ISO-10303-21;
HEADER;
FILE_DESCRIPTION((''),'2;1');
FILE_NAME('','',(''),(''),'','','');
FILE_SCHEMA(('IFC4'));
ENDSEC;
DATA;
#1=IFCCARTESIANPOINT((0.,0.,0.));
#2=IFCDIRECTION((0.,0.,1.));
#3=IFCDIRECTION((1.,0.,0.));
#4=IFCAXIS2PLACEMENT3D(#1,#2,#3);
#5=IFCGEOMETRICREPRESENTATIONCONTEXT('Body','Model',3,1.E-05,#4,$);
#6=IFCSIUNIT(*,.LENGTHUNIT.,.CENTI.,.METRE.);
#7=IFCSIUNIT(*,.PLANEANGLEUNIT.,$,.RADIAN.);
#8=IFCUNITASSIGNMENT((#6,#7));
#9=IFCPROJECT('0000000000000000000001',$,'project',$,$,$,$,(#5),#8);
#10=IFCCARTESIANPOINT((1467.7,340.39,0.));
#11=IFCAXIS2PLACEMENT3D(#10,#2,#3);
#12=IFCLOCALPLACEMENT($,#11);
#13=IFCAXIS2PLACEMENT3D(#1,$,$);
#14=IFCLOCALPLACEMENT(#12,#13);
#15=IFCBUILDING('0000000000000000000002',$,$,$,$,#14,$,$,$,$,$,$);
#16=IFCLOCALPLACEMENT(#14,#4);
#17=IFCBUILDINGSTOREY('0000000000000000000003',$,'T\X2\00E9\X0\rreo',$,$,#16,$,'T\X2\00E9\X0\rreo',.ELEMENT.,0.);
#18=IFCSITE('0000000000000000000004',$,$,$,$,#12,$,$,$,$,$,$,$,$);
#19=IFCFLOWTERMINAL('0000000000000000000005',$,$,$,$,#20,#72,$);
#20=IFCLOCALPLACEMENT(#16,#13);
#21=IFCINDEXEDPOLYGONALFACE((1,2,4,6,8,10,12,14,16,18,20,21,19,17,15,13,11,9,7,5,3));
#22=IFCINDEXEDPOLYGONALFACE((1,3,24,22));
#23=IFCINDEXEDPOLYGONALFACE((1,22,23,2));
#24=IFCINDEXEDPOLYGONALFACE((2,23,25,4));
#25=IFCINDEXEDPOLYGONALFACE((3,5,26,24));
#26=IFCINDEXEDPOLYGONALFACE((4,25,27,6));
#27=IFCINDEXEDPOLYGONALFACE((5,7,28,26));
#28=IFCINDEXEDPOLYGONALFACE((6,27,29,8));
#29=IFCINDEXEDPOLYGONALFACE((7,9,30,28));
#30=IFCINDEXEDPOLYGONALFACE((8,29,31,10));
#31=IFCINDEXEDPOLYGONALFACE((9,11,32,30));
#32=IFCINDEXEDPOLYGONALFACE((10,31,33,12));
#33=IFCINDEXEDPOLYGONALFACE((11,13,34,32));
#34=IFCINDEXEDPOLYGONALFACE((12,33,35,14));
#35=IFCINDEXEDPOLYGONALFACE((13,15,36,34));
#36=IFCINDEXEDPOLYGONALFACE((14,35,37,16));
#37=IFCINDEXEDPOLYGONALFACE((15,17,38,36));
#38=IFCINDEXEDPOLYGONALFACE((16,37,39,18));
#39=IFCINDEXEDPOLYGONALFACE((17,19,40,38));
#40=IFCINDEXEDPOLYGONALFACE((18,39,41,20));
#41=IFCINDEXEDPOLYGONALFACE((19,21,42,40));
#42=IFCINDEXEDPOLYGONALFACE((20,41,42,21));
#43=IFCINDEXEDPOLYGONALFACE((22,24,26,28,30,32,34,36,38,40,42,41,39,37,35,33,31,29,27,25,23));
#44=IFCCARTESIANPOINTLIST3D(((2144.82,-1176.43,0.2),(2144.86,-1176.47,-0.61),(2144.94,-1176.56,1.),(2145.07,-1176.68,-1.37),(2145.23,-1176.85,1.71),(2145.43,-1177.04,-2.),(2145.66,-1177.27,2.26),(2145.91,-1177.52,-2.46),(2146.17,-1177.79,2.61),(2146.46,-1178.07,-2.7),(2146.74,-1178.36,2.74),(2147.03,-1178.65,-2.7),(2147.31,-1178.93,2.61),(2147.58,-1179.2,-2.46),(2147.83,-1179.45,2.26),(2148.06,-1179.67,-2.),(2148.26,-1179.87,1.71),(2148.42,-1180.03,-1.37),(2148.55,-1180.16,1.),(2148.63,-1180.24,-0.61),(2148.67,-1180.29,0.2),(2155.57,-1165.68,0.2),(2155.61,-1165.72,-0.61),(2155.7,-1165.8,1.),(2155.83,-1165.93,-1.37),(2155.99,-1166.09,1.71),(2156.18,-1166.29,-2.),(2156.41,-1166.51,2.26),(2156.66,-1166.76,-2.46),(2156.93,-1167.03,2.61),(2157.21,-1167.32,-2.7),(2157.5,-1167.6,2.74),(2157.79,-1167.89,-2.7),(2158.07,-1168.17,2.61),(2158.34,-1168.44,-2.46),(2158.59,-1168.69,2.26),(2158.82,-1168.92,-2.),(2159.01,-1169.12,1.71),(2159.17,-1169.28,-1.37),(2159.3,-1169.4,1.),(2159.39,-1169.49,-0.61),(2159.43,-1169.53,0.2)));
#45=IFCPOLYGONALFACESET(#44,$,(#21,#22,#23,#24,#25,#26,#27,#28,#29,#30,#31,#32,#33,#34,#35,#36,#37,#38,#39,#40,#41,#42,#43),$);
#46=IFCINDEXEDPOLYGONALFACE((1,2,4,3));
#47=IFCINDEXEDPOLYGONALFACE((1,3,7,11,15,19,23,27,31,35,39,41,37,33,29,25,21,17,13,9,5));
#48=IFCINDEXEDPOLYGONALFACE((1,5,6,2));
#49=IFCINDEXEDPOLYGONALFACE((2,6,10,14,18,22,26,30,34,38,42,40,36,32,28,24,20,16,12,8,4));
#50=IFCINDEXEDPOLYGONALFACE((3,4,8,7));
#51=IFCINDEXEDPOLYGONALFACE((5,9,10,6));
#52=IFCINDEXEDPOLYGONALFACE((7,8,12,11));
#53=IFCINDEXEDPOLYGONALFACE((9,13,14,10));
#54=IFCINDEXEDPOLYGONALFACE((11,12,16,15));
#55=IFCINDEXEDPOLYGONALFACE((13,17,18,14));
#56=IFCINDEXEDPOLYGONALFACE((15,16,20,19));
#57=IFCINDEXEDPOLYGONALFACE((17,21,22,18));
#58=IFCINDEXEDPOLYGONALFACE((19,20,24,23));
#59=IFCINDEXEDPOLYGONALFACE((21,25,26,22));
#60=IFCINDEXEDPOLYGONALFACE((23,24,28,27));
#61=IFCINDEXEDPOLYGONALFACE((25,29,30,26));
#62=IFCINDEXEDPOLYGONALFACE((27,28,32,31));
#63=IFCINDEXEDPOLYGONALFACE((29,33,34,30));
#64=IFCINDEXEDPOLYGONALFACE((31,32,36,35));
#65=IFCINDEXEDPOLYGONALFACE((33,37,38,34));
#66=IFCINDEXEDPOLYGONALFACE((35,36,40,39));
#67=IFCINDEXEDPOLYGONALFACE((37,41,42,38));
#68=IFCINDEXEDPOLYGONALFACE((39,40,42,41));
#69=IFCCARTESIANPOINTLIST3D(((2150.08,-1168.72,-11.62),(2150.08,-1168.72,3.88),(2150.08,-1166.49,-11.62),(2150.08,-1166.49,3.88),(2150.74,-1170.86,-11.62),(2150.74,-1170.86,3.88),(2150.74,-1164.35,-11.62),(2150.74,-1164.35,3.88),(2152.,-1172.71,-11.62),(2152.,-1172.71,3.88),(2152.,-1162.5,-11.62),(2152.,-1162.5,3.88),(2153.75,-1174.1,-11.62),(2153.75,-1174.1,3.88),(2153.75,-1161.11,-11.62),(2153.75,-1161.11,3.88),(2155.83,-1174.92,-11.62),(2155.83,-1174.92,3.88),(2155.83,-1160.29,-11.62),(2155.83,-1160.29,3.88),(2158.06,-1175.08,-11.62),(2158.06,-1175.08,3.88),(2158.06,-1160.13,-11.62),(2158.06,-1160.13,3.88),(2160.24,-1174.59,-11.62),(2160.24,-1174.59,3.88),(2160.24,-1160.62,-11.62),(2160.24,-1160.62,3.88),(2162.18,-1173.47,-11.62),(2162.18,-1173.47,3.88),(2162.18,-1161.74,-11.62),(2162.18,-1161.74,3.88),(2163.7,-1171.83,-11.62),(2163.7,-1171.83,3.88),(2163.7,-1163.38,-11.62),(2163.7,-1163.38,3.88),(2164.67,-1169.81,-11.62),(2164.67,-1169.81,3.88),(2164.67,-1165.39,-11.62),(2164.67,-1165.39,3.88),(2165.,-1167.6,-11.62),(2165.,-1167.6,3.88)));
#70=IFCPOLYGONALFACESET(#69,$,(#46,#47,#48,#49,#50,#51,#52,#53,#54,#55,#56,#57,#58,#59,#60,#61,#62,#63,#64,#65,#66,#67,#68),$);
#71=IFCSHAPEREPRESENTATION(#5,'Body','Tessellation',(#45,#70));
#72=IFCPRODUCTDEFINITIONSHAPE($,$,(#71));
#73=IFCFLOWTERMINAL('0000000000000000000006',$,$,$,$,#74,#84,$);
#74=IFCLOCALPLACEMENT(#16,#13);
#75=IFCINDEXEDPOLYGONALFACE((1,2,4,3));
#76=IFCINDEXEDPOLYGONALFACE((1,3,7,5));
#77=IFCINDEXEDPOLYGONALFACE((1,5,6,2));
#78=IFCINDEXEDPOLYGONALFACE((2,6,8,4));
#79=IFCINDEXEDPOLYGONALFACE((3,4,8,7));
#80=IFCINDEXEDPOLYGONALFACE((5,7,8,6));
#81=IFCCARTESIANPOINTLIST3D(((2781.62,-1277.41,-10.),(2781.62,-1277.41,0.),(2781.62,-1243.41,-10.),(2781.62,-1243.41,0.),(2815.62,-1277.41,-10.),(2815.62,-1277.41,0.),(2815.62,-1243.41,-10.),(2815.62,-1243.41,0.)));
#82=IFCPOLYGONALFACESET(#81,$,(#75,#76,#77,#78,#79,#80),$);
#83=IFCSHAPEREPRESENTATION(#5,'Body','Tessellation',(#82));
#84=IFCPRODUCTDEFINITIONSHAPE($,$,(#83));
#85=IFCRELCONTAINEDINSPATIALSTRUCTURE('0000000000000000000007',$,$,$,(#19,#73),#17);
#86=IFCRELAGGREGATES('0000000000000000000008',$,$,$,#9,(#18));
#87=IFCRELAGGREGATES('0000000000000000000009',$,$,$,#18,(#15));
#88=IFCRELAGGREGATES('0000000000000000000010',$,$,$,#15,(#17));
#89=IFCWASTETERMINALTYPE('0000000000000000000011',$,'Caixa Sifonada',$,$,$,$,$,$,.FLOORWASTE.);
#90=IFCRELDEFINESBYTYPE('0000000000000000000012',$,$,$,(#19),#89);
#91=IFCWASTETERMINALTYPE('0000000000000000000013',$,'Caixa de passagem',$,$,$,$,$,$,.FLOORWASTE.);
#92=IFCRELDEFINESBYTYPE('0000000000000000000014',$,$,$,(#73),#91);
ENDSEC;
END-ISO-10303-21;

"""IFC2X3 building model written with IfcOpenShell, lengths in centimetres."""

from ifc_helpers import new_model, si_unit, frame, origin, origin_with_axes, origin_2d_with_axis, place, context, project, spatial, rectangle, circle, extrude, type_object, element, save


model = new_model("IFC2X3")

# Units and contexts
model_context = context("Model", 3, precision=1e-05, world=origin_with_axes(), identifier="Body")
ifc_project = project(units=[si_unit("LENGTHUNIT", "METRE", prefix="CENTI"), si_unit("PLANEANGLEUNIT", "RADIAN")], contexts=[model_context])

# Site, building, storey
site_placement = place(None, frame((1467.7, 340.39, 0.0), z_axis=(0.0, 0.0, 1.0), x_axis=(1.0, 0.0, 0.0)))
site = spatial("IfcSite", under=ifc_project, at=site_placement)
building_placement = place(site_placement, origin())
building = spatial("IfcBuilding", under=site, at=building_placement)
storey_placement = place(building_placement, origin_with_axes())
storey = spatial("IfcBuildingStorey", under=building, at=storey_placement, Name="Térreo", LongName="Térreo", CompositionType="ELEMENT", Elevation=0.0)

# Flow terminals
waste_terminal_type_1 = type_object("IfcWasteTerminalType", Name="Caixa Sifonada", PredefinedType="FLOORWASTE")
flow_terminal_1_placement = place(storey_placement, frame((2154.91, -1170.2, 3.88), z_axis=(0.0, 0.0, 1.0), x_axis=(1.0, 0.0, 0.0)))
element("IfcFlowTerminal", 1, at=flow_terminal_1_placement, inside=storey, type_object=waste_terminal_type_1, context=model_context, shape_type="SolidModel", body=[
    extrude(circle(Radius=2.73, at=origin_2d_with_axis()), frame((2.59, 2.59, -3.88), z_axis=(-0.707107, -0.707107, 0.0), x_axis=(0.0, 0.0, 1.0)), (0.0, 0.0, 1.0), 15.21),
    extrude(circle(Radius=7.5, at=origin_2d_with_axis()), frame((2.59, 2.59, -15.5), z_axis=(0.0, 0.0, 1.0), x_axis=(1.0, 0.0, 0.0)), (0.0, 0.0, 1.0), 15.5),
])
waste_terminal_type_2 = type_object("IfcWasteTerminalType", Name="Caixa de passagem", PredefinedType="FLOORWASTE")
flow_terminal_2_placement = place(storey_placement, frame((2798.62, -1260.41, 0.0), z_axis=(0.0, 0.0, 1.0), x_axis=(1.0, 0.0, 0.0)))
element("IfcFlowTerminal", 2, at=flow_terminal_2_placement, inside=storey, type_object=waste_terminal_type_2, context=model_context, shape_type="SolidModel", body=[
    extrude(rectangle(XDim=34.0, YDim=34.0, at=origin_2d_with_axis()), frame((0.0, 0.0, -10.0), z_axis=(0.0, 0.0, 1.0), x_axis=(0.0, -1.0, 0.0)), (0.0, 0.0, 1.0), 10.0),
])

save(model, "model.ifc")
